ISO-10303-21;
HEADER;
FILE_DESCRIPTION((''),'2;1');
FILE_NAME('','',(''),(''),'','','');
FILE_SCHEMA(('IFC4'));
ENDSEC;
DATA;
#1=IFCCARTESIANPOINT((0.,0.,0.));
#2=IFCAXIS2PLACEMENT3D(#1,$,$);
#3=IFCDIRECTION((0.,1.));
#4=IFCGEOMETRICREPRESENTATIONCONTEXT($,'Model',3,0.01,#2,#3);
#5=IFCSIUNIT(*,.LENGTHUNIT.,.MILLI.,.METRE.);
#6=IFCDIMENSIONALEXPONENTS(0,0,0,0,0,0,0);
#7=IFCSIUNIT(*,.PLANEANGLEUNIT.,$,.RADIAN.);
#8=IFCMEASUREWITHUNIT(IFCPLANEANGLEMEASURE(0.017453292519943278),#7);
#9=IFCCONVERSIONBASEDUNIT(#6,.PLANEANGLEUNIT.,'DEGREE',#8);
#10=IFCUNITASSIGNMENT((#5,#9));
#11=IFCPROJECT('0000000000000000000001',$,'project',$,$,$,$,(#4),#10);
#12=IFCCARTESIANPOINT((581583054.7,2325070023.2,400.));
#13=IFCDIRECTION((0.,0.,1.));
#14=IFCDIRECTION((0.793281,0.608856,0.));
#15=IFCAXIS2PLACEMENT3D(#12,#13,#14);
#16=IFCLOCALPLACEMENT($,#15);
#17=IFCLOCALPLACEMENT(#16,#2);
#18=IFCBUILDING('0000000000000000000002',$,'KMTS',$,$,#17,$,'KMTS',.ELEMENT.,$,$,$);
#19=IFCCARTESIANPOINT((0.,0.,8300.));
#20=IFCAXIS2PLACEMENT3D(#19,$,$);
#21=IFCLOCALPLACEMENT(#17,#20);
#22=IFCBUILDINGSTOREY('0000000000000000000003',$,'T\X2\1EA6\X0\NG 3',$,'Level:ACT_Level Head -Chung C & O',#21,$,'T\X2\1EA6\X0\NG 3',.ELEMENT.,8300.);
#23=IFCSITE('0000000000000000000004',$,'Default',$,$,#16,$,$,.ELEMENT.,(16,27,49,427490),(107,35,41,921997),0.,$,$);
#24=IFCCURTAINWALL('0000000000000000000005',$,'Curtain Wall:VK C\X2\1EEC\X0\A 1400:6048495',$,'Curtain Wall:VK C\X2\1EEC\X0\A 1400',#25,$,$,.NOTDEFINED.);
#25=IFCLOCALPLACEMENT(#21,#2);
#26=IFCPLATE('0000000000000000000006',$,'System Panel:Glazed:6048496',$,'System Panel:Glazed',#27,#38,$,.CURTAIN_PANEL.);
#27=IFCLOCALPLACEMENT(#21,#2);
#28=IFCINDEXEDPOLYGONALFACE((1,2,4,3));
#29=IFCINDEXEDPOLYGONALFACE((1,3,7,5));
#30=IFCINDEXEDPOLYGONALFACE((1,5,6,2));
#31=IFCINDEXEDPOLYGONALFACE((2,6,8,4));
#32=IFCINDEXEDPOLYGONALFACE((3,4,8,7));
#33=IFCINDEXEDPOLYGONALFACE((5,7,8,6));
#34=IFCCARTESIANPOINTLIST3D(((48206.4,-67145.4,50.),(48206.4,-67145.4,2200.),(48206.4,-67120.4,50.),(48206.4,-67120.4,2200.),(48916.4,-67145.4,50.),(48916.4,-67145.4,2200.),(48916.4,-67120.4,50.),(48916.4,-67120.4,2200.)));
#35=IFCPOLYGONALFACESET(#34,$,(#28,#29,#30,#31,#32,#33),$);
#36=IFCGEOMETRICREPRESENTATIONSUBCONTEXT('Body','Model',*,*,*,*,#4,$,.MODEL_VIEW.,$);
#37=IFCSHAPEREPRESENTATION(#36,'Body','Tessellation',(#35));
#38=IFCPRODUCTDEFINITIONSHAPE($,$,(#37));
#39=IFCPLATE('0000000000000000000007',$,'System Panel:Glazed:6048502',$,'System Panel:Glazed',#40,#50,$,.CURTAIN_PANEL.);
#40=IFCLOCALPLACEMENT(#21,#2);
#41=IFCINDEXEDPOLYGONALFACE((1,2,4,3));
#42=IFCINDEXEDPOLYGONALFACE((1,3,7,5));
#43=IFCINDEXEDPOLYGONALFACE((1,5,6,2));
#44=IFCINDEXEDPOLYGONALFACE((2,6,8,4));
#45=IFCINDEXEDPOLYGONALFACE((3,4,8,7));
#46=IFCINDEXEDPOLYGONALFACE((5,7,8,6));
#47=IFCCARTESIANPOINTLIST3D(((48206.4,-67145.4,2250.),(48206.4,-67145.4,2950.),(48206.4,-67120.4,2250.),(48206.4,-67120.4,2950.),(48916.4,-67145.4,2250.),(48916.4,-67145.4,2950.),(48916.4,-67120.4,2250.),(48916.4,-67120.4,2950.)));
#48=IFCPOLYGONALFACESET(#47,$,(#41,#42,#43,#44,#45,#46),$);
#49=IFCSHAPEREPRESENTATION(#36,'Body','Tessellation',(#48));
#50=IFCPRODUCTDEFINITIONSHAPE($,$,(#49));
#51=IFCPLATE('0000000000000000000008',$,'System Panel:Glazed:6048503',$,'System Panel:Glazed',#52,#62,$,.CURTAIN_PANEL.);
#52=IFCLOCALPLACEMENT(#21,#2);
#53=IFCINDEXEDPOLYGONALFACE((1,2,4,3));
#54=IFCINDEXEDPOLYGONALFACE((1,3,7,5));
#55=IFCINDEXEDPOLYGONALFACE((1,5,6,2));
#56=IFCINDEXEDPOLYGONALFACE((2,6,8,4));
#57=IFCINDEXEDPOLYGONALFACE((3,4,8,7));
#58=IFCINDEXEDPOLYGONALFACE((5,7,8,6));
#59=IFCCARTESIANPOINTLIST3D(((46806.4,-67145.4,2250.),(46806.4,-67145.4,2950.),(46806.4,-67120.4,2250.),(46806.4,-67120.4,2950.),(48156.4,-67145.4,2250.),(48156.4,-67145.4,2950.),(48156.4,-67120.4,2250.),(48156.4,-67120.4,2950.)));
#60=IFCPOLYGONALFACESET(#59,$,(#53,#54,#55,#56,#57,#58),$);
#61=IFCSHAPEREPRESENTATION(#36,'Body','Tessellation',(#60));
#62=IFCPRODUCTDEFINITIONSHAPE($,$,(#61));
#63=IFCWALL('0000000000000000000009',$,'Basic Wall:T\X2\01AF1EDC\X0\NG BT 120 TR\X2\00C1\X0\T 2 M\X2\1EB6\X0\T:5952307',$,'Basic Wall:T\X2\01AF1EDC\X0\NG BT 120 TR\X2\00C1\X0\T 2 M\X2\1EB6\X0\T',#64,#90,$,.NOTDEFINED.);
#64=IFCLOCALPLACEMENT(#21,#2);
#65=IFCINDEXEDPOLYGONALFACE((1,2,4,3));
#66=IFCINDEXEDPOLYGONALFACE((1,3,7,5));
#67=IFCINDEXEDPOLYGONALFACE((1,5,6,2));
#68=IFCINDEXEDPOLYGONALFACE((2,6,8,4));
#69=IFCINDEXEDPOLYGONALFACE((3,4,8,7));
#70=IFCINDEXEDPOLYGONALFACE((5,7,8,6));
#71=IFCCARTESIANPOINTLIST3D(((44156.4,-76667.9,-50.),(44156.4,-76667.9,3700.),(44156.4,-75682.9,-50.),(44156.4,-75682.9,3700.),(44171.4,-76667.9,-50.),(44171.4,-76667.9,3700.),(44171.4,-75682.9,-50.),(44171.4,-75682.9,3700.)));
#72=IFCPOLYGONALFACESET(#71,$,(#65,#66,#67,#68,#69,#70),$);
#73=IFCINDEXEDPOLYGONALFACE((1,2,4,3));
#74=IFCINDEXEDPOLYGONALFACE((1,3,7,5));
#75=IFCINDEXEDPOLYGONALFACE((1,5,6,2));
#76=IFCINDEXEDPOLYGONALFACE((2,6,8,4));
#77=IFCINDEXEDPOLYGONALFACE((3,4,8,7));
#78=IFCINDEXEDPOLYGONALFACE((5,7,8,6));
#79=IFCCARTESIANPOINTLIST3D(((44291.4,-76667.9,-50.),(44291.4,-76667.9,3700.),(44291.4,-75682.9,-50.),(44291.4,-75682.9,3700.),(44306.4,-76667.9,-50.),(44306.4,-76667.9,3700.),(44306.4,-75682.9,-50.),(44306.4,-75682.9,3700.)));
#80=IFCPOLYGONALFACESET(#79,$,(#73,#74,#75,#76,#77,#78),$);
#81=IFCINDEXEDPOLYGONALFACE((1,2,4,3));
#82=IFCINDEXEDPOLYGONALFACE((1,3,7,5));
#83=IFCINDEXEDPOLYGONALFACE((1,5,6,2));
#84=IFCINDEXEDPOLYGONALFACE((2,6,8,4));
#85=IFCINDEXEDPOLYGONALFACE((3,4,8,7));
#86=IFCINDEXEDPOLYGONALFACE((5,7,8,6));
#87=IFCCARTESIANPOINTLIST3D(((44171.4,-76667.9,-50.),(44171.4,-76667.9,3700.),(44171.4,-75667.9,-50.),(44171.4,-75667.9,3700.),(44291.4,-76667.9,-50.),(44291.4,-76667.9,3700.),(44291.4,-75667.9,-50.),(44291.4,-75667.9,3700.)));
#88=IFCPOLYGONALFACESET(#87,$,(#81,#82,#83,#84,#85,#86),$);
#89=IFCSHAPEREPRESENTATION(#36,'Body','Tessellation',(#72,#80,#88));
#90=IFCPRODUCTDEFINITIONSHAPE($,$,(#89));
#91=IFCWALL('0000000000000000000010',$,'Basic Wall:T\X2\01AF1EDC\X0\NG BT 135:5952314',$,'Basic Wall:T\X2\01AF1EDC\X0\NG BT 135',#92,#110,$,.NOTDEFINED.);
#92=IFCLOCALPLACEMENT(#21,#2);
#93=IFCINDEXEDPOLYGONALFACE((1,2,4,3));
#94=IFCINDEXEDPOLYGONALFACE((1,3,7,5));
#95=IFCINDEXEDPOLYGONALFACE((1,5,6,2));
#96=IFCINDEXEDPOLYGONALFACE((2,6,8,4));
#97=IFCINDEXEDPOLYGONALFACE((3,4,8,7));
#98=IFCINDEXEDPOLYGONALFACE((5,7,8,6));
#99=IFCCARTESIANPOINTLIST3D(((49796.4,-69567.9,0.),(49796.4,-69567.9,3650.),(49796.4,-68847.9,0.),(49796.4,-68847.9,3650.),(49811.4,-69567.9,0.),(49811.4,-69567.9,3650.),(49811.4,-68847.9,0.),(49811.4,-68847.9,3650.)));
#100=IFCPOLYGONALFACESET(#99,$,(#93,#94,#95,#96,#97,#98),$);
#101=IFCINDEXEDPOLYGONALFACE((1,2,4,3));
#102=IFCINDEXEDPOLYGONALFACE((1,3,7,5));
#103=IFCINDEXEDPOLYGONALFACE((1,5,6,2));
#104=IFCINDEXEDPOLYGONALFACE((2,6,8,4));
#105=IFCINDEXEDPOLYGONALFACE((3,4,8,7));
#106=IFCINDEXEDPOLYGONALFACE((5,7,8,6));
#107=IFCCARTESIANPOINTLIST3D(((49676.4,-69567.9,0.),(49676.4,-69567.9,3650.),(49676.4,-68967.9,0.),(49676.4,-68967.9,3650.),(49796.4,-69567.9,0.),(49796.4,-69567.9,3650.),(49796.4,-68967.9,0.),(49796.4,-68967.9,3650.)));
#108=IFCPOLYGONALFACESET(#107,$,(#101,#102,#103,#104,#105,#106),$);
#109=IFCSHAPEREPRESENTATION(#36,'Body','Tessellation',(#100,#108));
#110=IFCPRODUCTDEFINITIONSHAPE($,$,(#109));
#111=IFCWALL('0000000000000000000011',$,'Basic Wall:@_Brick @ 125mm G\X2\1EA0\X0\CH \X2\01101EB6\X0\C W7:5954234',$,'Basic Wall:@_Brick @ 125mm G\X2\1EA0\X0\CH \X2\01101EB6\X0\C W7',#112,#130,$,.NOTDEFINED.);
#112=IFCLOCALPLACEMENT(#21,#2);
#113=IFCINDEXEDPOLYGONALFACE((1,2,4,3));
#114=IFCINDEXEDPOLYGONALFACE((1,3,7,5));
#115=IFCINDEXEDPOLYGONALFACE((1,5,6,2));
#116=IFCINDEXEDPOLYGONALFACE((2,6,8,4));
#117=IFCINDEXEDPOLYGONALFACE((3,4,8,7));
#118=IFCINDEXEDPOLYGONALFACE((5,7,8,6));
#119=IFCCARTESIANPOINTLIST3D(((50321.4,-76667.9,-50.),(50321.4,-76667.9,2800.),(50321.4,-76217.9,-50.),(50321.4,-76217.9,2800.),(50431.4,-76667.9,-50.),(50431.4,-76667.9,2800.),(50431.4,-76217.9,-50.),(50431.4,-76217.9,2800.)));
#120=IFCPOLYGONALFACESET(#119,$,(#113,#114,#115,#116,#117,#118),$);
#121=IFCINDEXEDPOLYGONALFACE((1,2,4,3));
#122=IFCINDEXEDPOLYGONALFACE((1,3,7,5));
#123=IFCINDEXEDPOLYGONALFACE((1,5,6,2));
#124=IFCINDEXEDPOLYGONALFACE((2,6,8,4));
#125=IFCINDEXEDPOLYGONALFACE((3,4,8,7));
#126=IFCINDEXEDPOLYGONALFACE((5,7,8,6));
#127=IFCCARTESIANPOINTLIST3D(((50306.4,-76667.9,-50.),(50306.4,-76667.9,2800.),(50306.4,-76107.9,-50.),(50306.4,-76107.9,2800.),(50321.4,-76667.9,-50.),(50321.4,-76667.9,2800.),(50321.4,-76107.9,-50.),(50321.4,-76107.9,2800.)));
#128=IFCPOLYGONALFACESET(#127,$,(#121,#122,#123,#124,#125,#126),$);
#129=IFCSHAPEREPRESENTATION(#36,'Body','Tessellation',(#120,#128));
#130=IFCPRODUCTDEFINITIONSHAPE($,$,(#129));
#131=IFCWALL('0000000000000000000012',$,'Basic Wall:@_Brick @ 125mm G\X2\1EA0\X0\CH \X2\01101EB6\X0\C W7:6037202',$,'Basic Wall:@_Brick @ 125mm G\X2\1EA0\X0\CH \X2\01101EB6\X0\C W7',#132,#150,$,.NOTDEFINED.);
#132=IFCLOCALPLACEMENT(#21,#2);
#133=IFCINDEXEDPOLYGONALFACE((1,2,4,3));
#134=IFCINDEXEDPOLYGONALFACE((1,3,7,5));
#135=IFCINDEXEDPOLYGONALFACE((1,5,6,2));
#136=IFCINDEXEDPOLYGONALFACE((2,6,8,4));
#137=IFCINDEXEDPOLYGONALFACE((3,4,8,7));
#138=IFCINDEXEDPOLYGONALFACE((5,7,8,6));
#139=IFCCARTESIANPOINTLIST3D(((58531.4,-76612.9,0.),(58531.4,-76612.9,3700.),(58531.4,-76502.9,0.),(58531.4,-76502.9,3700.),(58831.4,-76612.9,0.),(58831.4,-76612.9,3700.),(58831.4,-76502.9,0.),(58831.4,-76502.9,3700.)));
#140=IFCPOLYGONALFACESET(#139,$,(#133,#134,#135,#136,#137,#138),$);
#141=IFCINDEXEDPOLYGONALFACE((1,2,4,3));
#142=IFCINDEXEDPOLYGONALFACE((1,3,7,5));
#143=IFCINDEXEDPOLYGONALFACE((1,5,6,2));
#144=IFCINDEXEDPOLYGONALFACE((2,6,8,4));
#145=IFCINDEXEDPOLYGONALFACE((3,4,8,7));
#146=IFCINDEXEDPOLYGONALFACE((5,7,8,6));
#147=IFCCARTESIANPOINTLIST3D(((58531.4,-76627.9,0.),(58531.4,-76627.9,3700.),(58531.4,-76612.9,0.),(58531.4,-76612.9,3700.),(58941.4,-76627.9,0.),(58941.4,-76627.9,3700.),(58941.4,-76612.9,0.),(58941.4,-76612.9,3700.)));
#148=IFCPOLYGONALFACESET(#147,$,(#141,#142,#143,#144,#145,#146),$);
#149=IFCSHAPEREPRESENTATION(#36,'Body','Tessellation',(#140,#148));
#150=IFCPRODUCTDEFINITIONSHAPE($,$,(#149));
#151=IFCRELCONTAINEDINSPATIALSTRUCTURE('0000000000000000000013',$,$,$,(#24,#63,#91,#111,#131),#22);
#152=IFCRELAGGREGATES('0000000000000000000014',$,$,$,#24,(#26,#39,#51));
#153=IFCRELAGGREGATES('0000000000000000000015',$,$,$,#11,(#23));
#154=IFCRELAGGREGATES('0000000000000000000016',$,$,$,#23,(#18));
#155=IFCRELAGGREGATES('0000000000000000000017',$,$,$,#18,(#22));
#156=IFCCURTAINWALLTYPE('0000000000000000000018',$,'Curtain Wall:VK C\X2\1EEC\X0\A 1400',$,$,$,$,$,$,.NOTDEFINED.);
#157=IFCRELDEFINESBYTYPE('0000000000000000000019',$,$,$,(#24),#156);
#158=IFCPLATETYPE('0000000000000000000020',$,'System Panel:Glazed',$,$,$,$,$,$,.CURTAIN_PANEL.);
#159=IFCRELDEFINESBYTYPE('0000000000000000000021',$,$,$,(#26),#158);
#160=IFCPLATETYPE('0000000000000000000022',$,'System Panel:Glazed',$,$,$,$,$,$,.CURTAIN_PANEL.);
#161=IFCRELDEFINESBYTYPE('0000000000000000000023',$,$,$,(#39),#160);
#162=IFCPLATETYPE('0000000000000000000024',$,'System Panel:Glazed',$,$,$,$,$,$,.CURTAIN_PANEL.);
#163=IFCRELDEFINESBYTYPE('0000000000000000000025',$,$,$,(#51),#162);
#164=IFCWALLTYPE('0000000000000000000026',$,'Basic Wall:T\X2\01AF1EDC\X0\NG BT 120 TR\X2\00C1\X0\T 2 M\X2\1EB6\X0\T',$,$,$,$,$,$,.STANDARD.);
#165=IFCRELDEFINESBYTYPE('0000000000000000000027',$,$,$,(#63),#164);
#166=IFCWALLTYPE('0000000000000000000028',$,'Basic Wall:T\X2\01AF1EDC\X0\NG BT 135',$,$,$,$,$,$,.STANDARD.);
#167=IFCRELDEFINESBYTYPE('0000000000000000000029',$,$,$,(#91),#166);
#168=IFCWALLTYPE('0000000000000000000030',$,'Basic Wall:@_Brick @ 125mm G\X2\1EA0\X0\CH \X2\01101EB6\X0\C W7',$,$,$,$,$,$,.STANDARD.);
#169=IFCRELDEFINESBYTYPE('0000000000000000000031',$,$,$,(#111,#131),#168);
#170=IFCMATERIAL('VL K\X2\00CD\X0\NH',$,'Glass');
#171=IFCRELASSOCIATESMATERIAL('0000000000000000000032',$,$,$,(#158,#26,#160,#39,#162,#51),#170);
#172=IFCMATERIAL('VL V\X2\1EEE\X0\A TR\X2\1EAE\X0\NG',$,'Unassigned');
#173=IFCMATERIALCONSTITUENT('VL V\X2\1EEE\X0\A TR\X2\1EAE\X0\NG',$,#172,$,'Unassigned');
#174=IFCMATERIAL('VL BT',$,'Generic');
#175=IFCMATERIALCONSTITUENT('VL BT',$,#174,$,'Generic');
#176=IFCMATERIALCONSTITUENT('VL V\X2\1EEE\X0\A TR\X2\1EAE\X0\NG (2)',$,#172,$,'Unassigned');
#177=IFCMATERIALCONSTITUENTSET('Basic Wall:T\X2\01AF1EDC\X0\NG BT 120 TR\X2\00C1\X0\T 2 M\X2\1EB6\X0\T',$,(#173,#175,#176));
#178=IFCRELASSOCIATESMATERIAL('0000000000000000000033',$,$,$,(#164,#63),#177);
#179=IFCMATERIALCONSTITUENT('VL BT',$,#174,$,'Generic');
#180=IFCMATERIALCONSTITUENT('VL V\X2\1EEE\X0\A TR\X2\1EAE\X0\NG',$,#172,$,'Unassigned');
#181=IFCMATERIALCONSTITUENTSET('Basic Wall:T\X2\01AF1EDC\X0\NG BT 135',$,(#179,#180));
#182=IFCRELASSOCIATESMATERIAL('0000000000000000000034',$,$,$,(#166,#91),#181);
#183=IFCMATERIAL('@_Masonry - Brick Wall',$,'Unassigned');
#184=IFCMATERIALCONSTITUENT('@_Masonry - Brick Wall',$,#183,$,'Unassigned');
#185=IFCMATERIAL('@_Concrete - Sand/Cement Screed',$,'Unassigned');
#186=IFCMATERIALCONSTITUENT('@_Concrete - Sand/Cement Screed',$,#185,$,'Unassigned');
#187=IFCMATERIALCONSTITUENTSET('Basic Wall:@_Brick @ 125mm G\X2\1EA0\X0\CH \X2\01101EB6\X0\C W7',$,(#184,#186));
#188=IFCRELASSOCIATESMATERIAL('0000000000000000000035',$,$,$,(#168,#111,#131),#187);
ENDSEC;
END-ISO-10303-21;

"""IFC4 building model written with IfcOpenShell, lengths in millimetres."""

from ifc_helpers import new_model, entity, si_unit, converted_unit, direction, frame, origin, place, context, subcontext, project, spatial, indexed_curve, outline, extrude, source, transform, mapped, material, constituent, constituent_set, type_object, type_shapes, element, aggregate, save


model = new_model("IFC4")

# Units and contexts
model_context = context("Model", 3, precision=0.01, world=origin(), true_north=direction((0.0, 1.0)))
body_context = subcontext(model_context, "Body", "Model", "MODEL_VIEW")
ifc_project = project(units=[si_unit("LENGTHUNIT", "METRE", prefix="MILLI"), converted_unit("PLANEANGLEUNIT", "DEGREE", entity("IfcPlaneAngleMeasure", 0.017453292519943278), si_unit("PLANEANGLEUNIT", "RADIAN"), dimensions=[0, 0, 0, 0, 0, 0, 0])], contexts=[model_context])

# Site, building, storey
site_placement = place(None, frame((581583054.7, 2325070023.2, 400.0), z_axis=(0.0, 0.0, 1.0), x_axis=(0.793281, 0.608856, 0.0)))
site = spatial("IfcSite", under=ifc_project, at=site_placement, Name="Default", CompositionType="ELEMENT", RefLatitude=(16, 27, 49, 427490), RefLongitude=(107, 35, 41, 921997), RefElevation=0.0)
building_placement = place(site_placement, origin())
building = spatial("IfcBuilding", under=site, at=building_placement, Name="KMTS", LongName="KMTS", CompositionType="ELEMENT")
storey_placement = place(building_placement, frame((0.0, 0.0, 8300.0)))
storey = spatial("IfcBuildingStorey", under=building, at=storey_placement, Name="TẦNG 3", ObjectType="Level:ACT_Level Head -Chung C & O", LongName="TẦNG 3", CompositionType="ELEMENT", Elevation=8300.0)

# Curtain wall, plates
curtain_wall_type = type_object("IfcCurtainWallType", Name="Curtain Wall:VK CỬA 1400", PredefinedType="NOTDEFINED")
curtain_wall_placement = place(storey_placement, frame((0.0, 0.0, -8300.0)))
curtain_wall = element("IfcCurtainWall", 1, at=curtain_wall_placement, inside=storey, type_object=curtain_wall_type, Name="Curtain Wall:VK CỬA 1400:6048495", ObjectType="Curtain Wall:VK CỬA 1400", PredefinedType="NOTDEFINED")
ifc_material_1 = material(Name="VL KÍNH", Category="Glass")
plate_type_1 = type_object("IfcPlateType", Name="System Panel:Glazed", PredefinedType="CURTAIN_PANEL", material=ifc_material_1)
shared_shape_1 = source(origin(), body_context, "Body", "SweptSolid", [
    extrude(outline(indexed_curve([(-12.5, -355.0), (12.5, -355.0), (12.5, 355.0), (-12.5, 355.0), (-12.5, -355.0)], self_intersect=False)), frame((0.0, 0.0, 0.0), z_axis=(0.0, 0.0, 1.0), x_axis=(0.0, 1.0, 0.0)), (0.0, 0.0, 1.0), 2150.0),
])
type_shapes(plate_type_1, [shared_shape_1])
plate_1_placement = place(curtain_wall_placement, frame((48561.4, -67132.9, 8350.0), z_axis=(0.0, 0.0, 1.0), x_axis=(-1.0, 0.0, 0.0)))
plate_1 = element("IfcPlate", 2, at=plate_1_placement, type_object=plate_type_1, material=ifc_material_1, Name="System Panel:Glazed:6048496", ObjectType="System Panel:Glazed", PredefinedType="CURTAIN_PANEL", context=body_context, shape_type="MappedRepresentation", body=[
    mapped(shared_shape_1, transform((0.0, 0.0, 0.0), scale=1.0)),
])
plate_type_2 = type_object("IfcPlateType", Name="System Panel:Glazed", PredefinedType="CURTAIN_PANEL", material=ifc_material_1)
shared_shape_2 = source(origin(), body_context, "Body", "SweptSolid", [
    extrude(outline(indexed_curve([(-12.5, -355.0), (12.5, -355.0), (12.5, 355.0), (-12.5, 355.0), (-12.5, -355.0)], self_intersect=False)), frame((0.0, 0.0, 0.0), z_axis=(0.0, 0.0, 1.0), x_axis=(0.0, 1.0, 0.0)), (0.0, 0.0, 1.0), 700.0),
])
type_shapes(plate_type_2, [shared_shape_2])
plate_2_placement = place(curtain_wall_placement, frame((48561.4, -67132.9, 10550.0), z_axis=(0.0, 0.0, 1.0), x_axis=(-1.0, 0.0, 0.0)))
plate_2 = element("IfcPlate", 3, at=plate_2_placement, type_object=plate_type_2, material=ifc_material_1, Name="System Panel:Glazed:6048502", ObjectType="System Panel:Glazed", PredefinedType="CURTAIN_PANEL", context=body_context, shape_type="MappedRepresentation", body=[
    mapped(shared_shape_2, transform((0.0, 0.0, 0.0), scale=1.0)),
])
plate_type_3 = type_object("IfcPlateType", Name="System Panel:Glazed", PredefinedType="CURTAIN_PANEL", material=ifc_material_1)
shared_shape_3 = source(origin(), body_context, "Body", "SweptSolid", [
    extrude(outline(indexed_curve([(-12.5, -675.0), (12.5, -675.0), (12.5, 675.0), (-12.5, 675.0), (-12.5, -675.0)], self_intersect=False)), frame((0.0, 0.0, 0.0), z_axis=(0.0, 0.0, 1.0), x_axis=(0.0, 1.0, 0.0)), (0.0, 0.0, 1.0), 700.0),
])
type_shapes(plate_type_3, [shared_shape_3])
plate_3_placement = place(curtain_wall_placement, frame((47481.4, -67132.9, 10550.0), z_axis=(0.0, 0.0, 1.0), x_axis=(-1.0, 0.0, 0.0)))
plate_3 = element("IfcPlate", 4, at=plate_3_placement, type_object=plate_type_3, material=ifc_material_1, Name="System Panel:Glazed:6048503", ObjectType="System Panel:Glazed", PredefinedType="CURTAIN_PANEL", context=body_context, shape_type="MappedRepresentation", body=[
    mapped(shared_shape_3, transform((0.0, 0.0, 0.0), scale=1.0)),
])

# Shared definitions
ifc_material_2 = material(Name="VL VỮA TRẮNG", Category="Unassigned")
ifc_material_3 = material(Name="VL BT", Category="Generic")

# Shared definitions
ifc_constituent_1 = constituent(ifc_material_2, Name="VL VỮA TRẮNG", Category="Unassigned")
ifc_constituent_2 = constituent(ifc_material_3, Name="VL BT", Category="Generic")
ifc_constituent_3 = constituent(ifc_material_2, Name="VL VỮA TRẮNG (2)", Category="Unassigned")
ifc_constituent_set_1 = constituent_set(constituents=[ifc_constituent_1, ifc_constituent_2, ifc_constituent_3], Name="Basic Wall:TƯỜNG BT 120 TRÁT 2 MẶT")
wall_type_1 = type_object("IfcWallType", Name="Basic Wall:TƯỜNG BT 120 TRÁT 2 MẶT", PredefinedType="STANDARD", material=ifc_constituent_set_1)

# Wall
wall_1_placement = place(storey_placement, frame((44231.4, -75682.9, -50.0), z_axis=(0.0, 0.0, 1.0), x_axis=(0.0, -1.0, 0.0)))
element("IfcWall", 5, at=wall_1_placement, inside=storey, type_object=wall_type_1, material=ifc_constituent_set_1, Name="Basic Wall:TƯỜNG BT 120 TRÁT 2 MẶT:5952307", ObjectType="Basic Wall:TƯỜNG BT 120 TRÁT 2 MẶT", PredefinedType="NOTDEFINED", context=body_context, shape_type="SweptSolid", body=[
    extrude(outline(indexed_curve([(-7.5, -492.5), (7.5, -492.5), (7.5, 492.5), (-7.5, 492.5), (-7.5, -492.5)], self_intersect=False)), frame((492.5, -67.5, 0.0), z_axis=(0.0, 0.0, 1.0), x_axis=(0.0, 1.0, 0.0)), (0.0, 0.0, 1.0), 3750.0),
    extrude(outline(indexed_curve([(-7.5, -492.5), (7.5, -492.5), (7.5, 492.5), (-7.5, 492.5), (-7.5, -492.5)], self_intersect=False)), frame((492.5, 67.5, 0.0), z_axis=(0.0, 0.0, 1.0), x_axis=(0.0, -1.0, 0.0)), (0.0, 0.0, 1.0), 3750.0),
    extrude(outline(indexed_curve([(-500.0, -60.0), (500.0, -60.0), (500.0, 60.0), (-500.0, 60.0), (-500.0, -60.0)], self_intersect=False)), frame((485.0, 0.0, 0.0)), (0.0, 0.0, 1.0), 3750.0),
])

# Wall
ifc_constituent_4 = constituent(ifc_material_3, Name="VL BT", Category="Generic")
ifc_constituent_5 = constituent(ifc_material_2, Name="VL VỮA TRẮNG", Category="Unassigned")
ifc_constituent_set_2 = constituent_set(constituents=[ifc_constituent_4, ifc_constituent_5], Name="Basic Wall:TƯỜNG BT 135")
wall_type_2 = type_object("IfcWallType", Name="Basic Wall:TƯỜNG BT 135", PredefinedType="STANDARD", material=ifc_constituent_set_2)
wall_2_placement = place(storey_placement, frame((49743.9, -68967.9, 0.0), z_axis=(0.0, 0.0, 1.0), x_axis=(0.0, -1.0, 0.0)))
element("IfcWall", 6, at=wall_2_placement, inside=storey, type_object=wall_type_2, material=ifc_constituent_set_2, Name="Basic Wall:TƯỜNG BT 135:5952314", ObjectType="Basic Wall:TƯỜNG BT 135", PredefinedType="NOTDEFINED", context=body_context, shape_type="SweptSolid", body=[
    extrude(outline(indexed_curve([(-7.5, -360.0), (7.5, -360.0), (7.5, 360.0), (-7.5, 360.0), (-7.5, -360.0)], self_intersect=False)), frame((240.0, 60.0, 0.0), z_axis=(0.0, 0.0, 1.0), x_axis=(0.0, -1.0, 0.0)), (0.0, 0.0, 1.0), 3650.0),
    extrude(outline(indexed_curve([(-60.0, -300.0), (60.0, -300.0), (60.0, 300.0), (-60.0, 300.0), (-60.0, -300.0)], self_intersect=False)), frame((300.0, -7.5, 0.0), z_axis=(0.0, 0.0, 1.0), x_axis=(0.0, 1.0, 0.0)), (0.0, 0.0, 1.0), 3650.0),
])

aggregate(curtain_wall, [plate_1, plate_2, plate_3])

# Walls
ifc_material_4 = material(Name="@_Masonry - Brick Wall", Category="Unassigned")
ifc_constituent_6 = constituent(ifc_material_4, Name="@_Masonry - Brick Wall", Category="Unassigned")
ifc_material_5 = material(Name="@_Concrete - Sand/Cement Screed", Category="Unassigned")
ifc_constituent_7 = constituent(ifc_material_5, Name="@_Concrete - Sand/Cement Screed", Category="Unassigned")
ifc_constituent_set_3 = constituent_set(constituents=[ifc_constituent_6, ifc_constituent_7], Name="Basic Wall:@_Brick @ 125mm GẠCH ĐẶC W7")
wall_type_3 = type_object("IfcWallType", Name="Basic Wall:@_Brick @ 125mm GẠCH ĐẶC W7", PredefinedType="STANDARD", material=ifc_constituent_set_3)
wall_3_placement = place(storey_placement, frame((50368.9, -76217.9, -50.0), z_axis=(0.0, 0.0, 1.0), x_axis=(0.0, -1.0, 0.0)))
element("IfcWall", 7, at=wall_3_placement, inside=storey, type_object=wall_type_3, material=ifc_constituent_set_3, Name="Basic Wall:@_Brick @ 125mm GẠCH ĐẶC W7:5954234", ObjectType="Basic Wall:@_Brick @ 125mm GẠCH ĐẶC W7", PredefinedType="NOTDEFINED", context=body_context, shape_type="SweptSolid", body=[
    extrude(outline(indexed_curve([(-55.0, -225.0), (55.0, -225.0), (55.0, 225.0), (-55.0, 225.0), (-55.0, -225.0)], self_intersect=False)), frame((225.0, 7.5, 0.0), z_axis=(0.0, 0.0, 1.0), x_axis=(0.0, -1.0, 0.0)), (0.0, 0.0, 1.0), 2850.0),
    extrude(outline(indexed_curve([(-7.5, -280.0), (7.5, -280.0), (7.5, 280.0), (-7.5, 280.0), (-7.5, -280.0)], self_intersect=False)), frame((170.0, -55.0, 0.0), z_axis=(0.0, 0.0, 1.0), x_axis=(0.0, 1.0, 0.0)), (0.0, 0.0, 1.0), 2850.0),
])
wall_4_placement = place(storey_placement, frame((58831.4, -76565.4, 0.0), z_axis=(0.0, 0.0, 1.0), x_axis=(-1.0, 0.0, 0.0)))
element("IfcWall", 8, at=wall_4_placement, inside=storey, type_object=wall_type_3, material=ifc_constituent_set_3, Name="Basic Wall:@_Brick @ 125mm GẠCH ĐẶC W7:6037202", ObjectType="Basic Wall:@_Brick @ 125mm GẠCH ĐẶC W7", PredefinedType="NOTDEFINED", context=body_context, shape_type="SweptSolid", body=[
    extrude(outline(indexed_curve([(-55.0, -150.0), (55.0, -150.0), (55.0, 150.0), (-55.0, 150.0), (-55.0, -150.0)], self_intersect=False)), frame((150.0, -7.5, 0.0), z_axis=(0.0, 0.0, 1.0), x_axis=(0.0, 1.0, 0.0)), (0.0, 0.0, 1.0), 3700.0),
    extrude(outline(indexed_curve([(-7.5, -205.0), (7.5, -205.0), (7.5, 205.0), (-7.5, 205.0), (-7.5, -205.0)], self_intersect=False)), frame((95.0, 55.0, 0.0), z_axis=(0.0, 0.0, 1.0), x_axis=(0.0, -1.0, 0.0)), (0.0, 0.0, 1.0), 3700.0),
])

save(model, "model.ifc")
